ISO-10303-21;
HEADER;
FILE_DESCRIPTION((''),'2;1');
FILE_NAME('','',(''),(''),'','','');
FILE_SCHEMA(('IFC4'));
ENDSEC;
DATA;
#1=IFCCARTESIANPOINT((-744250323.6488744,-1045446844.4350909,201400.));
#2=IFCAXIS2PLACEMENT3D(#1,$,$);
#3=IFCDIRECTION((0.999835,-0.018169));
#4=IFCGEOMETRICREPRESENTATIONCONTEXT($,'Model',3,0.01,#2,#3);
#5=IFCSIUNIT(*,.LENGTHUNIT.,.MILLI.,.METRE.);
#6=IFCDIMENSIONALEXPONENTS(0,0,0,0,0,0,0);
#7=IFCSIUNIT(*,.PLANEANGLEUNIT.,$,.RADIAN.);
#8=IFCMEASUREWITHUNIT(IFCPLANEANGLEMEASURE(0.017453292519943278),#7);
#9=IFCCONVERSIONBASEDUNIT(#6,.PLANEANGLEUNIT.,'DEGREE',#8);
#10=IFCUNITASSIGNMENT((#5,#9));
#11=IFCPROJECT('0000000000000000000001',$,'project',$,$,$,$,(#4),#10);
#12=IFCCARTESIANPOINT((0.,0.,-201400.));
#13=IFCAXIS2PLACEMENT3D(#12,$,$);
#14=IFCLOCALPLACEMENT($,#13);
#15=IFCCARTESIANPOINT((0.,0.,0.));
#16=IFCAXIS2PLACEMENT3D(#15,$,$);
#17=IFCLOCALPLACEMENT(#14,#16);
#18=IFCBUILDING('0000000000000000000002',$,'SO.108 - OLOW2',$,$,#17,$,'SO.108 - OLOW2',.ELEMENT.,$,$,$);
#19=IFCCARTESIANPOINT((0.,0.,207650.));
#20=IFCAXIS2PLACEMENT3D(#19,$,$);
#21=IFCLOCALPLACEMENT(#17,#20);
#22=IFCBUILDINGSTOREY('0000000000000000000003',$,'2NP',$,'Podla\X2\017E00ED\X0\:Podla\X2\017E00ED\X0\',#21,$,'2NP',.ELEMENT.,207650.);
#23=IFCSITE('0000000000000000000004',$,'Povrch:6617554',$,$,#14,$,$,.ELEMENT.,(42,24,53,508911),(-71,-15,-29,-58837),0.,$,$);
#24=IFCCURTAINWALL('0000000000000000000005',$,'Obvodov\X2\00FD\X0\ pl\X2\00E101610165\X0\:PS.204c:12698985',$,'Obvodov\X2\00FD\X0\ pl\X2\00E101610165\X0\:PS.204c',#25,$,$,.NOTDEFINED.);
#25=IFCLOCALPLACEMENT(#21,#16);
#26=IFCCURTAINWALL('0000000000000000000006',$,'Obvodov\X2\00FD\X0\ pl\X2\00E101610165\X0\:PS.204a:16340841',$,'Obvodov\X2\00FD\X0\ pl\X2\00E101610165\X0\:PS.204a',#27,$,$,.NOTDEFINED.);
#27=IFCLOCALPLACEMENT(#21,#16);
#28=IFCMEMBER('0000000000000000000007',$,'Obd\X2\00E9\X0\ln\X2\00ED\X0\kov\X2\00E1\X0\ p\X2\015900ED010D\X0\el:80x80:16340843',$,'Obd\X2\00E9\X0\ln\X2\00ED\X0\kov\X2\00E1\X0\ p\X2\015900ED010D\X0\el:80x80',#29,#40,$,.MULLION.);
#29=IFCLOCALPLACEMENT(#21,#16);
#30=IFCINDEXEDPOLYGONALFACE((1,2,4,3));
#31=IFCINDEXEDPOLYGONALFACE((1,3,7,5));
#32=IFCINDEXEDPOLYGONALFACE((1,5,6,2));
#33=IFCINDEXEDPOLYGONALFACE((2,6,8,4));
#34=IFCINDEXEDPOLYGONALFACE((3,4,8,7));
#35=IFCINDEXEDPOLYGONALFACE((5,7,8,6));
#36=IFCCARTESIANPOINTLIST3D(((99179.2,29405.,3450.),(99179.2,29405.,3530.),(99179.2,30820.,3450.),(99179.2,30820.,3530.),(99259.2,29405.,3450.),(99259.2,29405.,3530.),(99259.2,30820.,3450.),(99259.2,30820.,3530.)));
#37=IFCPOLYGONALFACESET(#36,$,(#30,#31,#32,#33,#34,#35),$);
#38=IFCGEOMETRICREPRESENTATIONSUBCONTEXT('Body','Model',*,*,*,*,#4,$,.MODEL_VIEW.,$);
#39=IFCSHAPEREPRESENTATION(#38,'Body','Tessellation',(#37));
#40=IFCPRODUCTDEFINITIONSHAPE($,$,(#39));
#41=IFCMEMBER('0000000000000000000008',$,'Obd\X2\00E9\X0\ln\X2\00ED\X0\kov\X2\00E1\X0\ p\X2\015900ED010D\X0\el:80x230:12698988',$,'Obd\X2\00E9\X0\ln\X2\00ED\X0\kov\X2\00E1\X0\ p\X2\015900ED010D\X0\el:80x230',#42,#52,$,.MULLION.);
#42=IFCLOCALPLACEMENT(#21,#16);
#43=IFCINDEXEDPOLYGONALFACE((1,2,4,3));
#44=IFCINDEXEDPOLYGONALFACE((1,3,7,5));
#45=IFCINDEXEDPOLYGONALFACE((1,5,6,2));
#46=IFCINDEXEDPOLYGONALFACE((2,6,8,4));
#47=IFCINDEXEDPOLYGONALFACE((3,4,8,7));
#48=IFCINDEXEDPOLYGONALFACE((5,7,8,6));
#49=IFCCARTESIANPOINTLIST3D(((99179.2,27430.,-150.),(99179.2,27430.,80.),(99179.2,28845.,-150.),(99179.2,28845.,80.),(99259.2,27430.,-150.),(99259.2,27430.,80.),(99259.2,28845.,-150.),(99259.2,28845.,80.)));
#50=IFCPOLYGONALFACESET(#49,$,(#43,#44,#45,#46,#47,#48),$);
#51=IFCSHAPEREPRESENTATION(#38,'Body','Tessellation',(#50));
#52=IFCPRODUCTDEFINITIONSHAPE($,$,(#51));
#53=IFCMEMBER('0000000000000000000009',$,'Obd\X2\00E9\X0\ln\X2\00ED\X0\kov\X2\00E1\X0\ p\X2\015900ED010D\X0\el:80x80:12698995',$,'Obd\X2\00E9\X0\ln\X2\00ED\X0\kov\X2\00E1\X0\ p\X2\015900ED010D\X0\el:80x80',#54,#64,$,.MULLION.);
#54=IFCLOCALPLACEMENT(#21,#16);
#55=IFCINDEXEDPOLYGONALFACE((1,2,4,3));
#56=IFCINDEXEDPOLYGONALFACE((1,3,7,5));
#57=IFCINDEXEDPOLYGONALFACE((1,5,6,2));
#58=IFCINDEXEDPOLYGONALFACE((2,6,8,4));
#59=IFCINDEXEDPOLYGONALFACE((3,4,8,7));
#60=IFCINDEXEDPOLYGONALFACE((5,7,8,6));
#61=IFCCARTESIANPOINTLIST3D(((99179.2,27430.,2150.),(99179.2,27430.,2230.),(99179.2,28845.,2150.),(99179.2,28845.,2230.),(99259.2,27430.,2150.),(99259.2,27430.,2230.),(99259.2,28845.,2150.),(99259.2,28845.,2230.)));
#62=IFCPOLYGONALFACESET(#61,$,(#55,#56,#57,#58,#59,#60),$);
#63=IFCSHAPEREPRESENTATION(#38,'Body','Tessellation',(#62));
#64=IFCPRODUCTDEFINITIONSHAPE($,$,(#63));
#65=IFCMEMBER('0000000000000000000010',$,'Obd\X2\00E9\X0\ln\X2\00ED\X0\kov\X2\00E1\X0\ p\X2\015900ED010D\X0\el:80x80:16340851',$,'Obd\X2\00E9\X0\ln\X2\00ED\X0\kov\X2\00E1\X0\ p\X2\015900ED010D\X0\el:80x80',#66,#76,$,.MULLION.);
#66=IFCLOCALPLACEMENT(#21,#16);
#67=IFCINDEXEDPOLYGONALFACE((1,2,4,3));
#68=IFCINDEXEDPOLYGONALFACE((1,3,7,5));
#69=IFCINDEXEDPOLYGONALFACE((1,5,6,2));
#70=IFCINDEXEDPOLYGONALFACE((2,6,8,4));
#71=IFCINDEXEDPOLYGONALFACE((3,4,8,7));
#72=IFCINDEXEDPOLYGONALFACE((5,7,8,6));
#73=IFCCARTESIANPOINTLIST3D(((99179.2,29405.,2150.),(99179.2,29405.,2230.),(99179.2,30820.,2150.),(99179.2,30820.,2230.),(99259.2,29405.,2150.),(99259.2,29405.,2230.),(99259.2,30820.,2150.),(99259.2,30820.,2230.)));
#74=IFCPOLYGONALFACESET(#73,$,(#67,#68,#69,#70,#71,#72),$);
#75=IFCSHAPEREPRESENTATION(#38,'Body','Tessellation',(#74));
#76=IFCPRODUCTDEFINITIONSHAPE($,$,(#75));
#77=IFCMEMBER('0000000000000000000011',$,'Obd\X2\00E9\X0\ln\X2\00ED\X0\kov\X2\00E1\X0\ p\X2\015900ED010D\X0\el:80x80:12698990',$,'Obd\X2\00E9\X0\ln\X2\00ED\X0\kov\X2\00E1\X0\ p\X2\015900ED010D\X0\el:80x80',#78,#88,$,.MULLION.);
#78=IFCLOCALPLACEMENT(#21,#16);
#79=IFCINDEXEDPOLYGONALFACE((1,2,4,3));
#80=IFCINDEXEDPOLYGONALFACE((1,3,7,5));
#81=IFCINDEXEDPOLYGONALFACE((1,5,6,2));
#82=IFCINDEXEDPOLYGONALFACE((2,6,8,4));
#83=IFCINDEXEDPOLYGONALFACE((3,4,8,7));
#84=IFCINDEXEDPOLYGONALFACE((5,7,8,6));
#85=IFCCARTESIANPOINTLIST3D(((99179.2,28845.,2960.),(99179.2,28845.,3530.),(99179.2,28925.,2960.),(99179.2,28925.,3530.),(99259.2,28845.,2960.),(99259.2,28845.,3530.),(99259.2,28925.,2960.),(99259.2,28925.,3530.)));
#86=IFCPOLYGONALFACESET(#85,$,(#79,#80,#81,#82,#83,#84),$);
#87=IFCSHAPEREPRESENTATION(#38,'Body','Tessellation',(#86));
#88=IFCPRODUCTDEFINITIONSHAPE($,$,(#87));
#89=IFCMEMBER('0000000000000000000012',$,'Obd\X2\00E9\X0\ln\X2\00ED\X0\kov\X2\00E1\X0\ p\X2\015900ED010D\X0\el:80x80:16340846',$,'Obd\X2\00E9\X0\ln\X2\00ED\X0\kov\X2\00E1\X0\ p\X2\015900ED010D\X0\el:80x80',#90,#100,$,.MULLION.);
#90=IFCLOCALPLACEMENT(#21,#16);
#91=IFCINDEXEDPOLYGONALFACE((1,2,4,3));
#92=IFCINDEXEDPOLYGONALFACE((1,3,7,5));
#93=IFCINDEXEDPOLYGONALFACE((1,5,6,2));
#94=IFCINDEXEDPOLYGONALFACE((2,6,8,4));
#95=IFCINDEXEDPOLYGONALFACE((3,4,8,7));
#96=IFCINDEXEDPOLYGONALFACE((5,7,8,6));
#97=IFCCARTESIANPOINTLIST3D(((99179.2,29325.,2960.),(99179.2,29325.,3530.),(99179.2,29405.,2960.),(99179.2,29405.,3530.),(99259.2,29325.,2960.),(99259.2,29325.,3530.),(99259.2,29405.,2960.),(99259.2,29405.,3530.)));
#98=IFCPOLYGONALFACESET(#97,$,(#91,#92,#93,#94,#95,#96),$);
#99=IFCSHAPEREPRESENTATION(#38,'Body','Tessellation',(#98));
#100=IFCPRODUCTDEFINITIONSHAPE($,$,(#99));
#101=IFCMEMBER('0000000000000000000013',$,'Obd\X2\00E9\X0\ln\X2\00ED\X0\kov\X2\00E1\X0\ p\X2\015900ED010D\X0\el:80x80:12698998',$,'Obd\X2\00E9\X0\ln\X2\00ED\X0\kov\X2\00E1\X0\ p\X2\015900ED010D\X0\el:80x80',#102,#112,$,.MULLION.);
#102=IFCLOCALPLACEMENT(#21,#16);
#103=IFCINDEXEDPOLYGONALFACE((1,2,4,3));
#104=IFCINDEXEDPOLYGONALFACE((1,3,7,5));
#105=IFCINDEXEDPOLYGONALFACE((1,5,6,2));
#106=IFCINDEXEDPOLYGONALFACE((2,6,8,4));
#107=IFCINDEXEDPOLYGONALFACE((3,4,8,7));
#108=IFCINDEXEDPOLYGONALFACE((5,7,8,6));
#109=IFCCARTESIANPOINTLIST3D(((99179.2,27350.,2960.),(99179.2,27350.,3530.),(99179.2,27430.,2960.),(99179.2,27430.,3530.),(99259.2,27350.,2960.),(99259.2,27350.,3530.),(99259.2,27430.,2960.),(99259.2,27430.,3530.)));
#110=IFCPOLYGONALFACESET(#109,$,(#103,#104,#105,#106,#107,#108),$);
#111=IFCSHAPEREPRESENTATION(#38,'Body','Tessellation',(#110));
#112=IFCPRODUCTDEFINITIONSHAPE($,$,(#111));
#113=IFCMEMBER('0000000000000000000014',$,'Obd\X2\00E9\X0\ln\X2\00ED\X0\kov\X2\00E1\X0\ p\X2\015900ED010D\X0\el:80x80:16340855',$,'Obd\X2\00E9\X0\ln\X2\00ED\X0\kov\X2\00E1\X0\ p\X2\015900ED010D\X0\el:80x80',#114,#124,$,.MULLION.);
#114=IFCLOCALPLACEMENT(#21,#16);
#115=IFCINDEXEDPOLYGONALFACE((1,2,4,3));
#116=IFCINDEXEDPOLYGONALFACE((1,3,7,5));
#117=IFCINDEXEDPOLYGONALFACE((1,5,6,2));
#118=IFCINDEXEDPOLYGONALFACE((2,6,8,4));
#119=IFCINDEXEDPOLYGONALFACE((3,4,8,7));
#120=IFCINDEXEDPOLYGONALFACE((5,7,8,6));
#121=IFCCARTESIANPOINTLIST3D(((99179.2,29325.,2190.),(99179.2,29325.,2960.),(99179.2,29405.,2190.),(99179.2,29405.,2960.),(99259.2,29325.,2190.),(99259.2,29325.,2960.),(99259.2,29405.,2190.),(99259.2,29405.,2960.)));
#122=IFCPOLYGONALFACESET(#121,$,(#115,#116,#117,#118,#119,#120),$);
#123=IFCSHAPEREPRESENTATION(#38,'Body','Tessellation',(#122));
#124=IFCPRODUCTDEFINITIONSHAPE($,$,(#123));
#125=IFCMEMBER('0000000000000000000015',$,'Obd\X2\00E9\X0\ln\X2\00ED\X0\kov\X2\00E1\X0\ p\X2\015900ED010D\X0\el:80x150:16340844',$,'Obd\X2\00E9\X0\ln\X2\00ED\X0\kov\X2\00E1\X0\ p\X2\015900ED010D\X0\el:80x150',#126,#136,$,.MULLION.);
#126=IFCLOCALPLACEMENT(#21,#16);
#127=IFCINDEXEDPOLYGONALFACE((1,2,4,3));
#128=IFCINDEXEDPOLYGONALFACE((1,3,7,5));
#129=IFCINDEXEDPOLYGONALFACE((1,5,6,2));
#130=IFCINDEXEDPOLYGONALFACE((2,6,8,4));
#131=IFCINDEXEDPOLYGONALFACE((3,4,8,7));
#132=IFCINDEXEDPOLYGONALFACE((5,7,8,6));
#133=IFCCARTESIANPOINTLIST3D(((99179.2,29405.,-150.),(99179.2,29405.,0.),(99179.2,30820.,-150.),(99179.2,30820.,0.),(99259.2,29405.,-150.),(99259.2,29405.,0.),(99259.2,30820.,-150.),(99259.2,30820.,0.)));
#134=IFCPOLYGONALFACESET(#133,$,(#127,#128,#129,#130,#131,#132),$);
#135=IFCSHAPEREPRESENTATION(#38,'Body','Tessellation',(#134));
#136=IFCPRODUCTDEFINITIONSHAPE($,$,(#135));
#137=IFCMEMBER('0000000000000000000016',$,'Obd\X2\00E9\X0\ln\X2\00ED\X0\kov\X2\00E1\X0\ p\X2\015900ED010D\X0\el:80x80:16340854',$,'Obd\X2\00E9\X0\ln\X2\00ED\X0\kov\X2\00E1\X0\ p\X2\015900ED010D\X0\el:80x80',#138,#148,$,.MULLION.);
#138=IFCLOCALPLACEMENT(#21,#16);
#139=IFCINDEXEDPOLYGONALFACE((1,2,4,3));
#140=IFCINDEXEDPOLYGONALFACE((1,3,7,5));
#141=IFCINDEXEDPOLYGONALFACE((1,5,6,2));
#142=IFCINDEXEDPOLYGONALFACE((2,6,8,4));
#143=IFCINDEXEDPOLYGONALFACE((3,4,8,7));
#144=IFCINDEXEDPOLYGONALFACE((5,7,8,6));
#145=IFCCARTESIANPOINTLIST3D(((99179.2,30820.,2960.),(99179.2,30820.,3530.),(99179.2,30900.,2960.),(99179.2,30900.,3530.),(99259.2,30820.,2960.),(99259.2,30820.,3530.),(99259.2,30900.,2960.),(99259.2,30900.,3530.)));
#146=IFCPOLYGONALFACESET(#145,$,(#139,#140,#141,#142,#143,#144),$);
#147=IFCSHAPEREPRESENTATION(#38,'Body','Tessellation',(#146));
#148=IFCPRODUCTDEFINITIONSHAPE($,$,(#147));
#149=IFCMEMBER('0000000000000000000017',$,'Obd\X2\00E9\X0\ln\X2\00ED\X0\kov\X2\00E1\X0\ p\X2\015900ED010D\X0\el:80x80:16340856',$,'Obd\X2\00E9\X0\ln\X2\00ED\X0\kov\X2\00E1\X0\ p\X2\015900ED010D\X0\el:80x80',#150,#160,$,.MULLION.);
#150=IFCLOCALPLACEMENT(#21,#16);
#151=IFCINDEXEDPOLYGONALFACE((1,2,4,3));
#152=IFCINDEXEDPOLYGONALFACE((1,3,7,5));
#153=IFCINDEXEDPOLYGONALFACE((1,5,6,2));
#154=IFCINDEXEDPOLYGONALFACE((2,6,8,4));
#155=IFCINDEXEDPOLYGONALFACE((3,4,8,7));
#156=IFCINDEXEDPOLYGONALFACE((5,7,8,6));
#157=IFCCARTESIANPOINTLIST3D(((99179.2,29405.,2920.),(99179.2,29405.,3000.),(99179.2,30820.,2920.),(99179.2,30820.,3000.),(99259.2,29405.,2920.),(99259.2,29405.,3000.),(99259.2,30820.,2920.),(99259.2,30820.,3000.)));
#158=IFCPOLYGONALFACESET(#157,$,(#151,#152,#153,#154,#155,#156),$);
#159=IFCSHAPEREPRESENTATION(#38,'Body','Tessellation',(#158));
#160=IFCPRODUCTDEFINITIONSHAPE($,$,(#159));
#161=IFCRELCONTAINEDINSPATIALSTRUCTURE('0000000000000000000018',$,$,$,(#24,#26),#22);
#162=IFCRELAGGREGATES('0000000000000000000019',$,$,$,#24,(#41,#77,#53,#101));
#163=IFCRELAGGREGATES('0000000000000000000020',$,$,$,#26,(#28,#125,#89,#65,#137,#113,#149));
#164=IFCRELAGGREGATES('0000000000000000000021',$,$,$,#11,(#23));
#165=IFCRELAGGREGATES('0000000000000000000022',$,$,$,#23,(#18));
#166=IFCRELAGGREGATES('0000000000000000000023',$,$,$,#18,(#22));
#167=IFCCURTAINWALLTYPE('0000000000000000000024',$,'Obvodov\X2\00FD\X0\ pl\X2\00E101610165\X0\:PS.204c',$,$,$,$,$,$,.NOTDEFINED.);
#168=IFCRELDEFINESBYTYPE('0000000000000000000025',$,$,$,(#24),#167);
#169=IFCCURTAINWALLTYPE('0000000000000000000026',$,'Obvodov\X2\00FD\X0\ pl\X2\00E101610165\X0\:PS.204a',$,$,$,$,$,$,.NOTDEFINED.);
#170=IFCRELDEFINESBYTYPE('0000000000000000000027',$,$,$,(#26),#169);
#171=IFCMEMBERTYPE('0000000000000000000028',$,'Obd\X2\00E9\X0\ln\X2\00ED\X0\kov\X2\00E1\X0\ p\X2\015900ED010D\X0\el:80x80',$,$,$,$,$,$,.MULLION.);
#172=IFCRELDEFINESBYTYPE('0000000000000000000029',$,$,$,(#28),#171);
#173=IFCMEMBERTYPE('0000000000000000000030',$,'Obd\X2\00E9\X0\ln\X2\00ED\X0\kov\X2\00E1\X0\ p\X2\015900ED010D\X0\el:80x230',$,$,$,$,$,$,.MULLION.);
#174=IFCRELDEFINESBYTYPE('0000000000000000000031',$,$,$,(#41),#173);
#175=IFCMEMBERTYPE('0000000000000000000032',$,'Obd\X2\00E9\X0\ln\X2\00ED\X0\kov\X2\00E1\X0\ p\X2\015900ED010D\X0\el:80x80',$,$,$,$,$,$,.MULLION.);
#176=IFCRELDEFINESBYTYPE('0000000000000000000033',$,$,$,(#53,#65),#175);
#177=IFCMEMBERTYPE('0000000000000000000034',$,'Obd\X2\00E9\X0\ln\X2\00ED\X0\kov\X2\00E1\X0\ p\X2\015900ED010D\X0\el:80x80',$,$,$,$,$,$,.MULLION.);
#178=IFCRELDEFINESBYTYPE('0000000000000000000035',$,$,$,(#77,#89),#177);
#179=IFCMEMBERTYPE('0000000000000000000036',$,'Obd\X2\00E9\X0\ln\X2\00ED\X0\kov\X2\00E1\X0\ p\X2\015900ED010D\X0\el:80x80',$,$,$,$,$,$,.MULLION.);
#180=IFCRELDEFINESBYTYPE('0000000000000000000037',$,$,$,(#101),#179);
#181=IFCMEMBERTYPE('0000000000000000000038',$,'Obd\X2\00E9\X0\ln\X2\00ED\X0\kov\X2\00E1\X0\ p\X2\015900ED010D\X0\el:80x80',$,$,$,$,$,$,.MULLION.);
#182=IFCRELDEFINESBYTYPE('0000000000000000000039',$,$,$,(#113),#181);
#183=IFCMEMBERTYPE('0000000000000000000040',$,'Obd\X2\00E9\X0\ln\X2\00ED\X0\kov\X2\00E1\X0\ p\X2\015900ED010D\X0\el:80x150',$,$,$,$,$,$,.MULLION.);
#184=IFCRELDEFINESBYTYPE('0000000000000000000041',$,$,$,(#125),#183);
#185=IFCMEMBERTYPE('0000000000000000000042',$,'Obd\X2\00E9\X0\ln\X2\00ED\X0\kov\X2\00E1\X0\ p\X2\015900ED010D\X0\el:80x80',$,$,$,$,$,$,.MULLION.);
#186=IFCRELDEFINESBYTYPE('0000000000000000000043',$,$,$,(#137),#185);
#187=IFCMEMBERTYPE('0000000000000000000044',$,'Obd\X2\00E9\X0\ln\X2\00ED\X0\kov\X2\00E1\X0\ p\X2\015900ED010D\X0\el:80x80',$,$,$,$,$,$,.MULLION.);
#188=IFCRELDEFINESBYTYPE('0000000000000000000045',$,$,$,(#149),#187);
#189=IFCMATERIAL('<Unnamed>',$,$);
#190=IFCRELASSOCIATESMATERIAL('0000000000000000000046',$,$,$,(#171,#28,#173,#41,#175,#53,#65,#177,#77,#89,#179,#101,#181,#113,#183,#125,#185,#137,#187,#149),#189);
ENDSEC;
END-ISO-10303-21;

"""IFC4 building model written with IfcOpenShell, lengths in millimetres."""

from ifc_helpers import new_model, entity, si_unit, converted_unit, direction, frame, origin, place, context, subcontext, project, spatial, indexed_curve, outline, extrude, source, transform, mapped, material, type_object, type_shapes, element, aggregate, save


model = new_model("IFC4")

# Units and contexts
model_context = context("Model", 3, precision=0.01, world=frame((-744250323.6488744, -1045446844.4350909, 201400.0)), true_north=direction((0.999835, -0.018169)))
body_context = subcontext(model_context, "Body", "Model", "MODEL_VIEW")
ifc_project = project(units=[si_unit("LENGTHUNIT", "METRE", prefix="MILLI"), converted_unit("PLANEANGLEUNIT", "DEGREE", entity("IfcPlaneAngleMeasure", 0.017453292519943278), si_unit("PLANEANGLEUNIT", "RADIAN"), dimensions=[0, 0, 0, 0, 0, 0, 0])], contexts=[model_context])

# Site, building, storey
site_placement = place(None, frame((0.0, 0.0, -201400.0)))
site = spatial("IfcSite", under=ifc_project, at=site_placement, Name="Povrch:6617554", CompositionType="ELEMENT", RefLatitude=(42, 24, 53, 508911), RefLongitude=(-71, -15, -29, -58837), RefElevation=0.0)
building_placement = place(site_placement, origin())
building = spatial("IfcBuilding", under=site, at=building_placement, Name="SO.108 - OLOW2", LongName="SO.108 - OLOW2", CompositionType="ELEMENT")
storey_placement = place(building_placement, frame((0.0, 0.0, 207650.0)))
storey = spatial("IfcBuildingStorey", under=building, at=storey_placement, Name="2NP", ObjectType="Podlaží:Podlaží", LongName="2NP", CompositionType="ELEMENT", Elevation=207650.0)

# Shared definitions
ifc_material_1 = material(Name="<Unnamed>")

# Curtain walls
curtain_wall_type_1 = type_object("IfcCurtainWallType", Name="Obvodový plášť:PS.204c", PredefinedType="NOTDEFINED")
curtain_wall_1_placement = place(storey_placement, frame((0.0, 0.0, -207650.0)))
curtain_wall_1 = element("IfcCurtainWall", 1, at=curtain_wall_1_placement, inside=storey, type_object=curtain_wall_type_1, Name="Obvodový plášť:PS.204c:12698985", ObjectType="Obvodový plášť:PS.204c", PredefinedType="NOTDEFINED")
curtain_wall_type_2 = type_object("IfcCurtainWallType", Name="Obvodový plášť:PS.204a", PredefinedType="NOTDEFINED")
curtain_wall_2_placement = place(storey_placement, frame((0.0, 0.0, -207650.0)))
curtain_wall_2 = element("IfcCurtainWall", 2, at=curtain_wall_2_placement, inside=storey, type_object=curtain_wall_type_2, Name="Obvodový plášť:PS.204a:16340841", ObjectType="Obvodový plášť:PS.204a", PredefinedType="NOTDEFINED")

# Members
member_type_1 = type_object("IfcMemberType", Name="Obdélníková příčel:80x80", PredefinedType="MULLION", material=ifc_material_1)
shared_shape_1 = source(origin(), body_context, "Body", "SweptSolid", [
    extrude(outline(indexed_curve([(-40.0, -40.0), (40.0, -40.0), (40.0, 40.0), (-40.0, 40.0), (-40.0, -40.0)], self_intersect=False)), frame((-40.0, 0.0, -1415.0), z_axis=(0.0, 0.0, 1.0), x_axis=(-1.0, 0.0, 0.0)), (0.0, 0.0, 1.0), 1415.0),
])
type_shapes(member_type_1, [shared_shape_1])
member_1_placement = place(curtain_wall_2_placement, frame((99219.2, 30820.0, 211180.0), z_axis=(0.0, 1.0, 0.0), x_axis=(0.0, 0.0, 1.0)))
member_1 = element("IfcMember", 3, at=member_1_placement, type_object=member_type_1, material=ifc_material_1, Name="Obdélníková příčel:80x80:16340843", ObjectType="Obdélníková příčel:80x80", PredefinedType="MULLION", context=body_context, shape_type="MappedRepresentation", body=[
    mapped(shared_shape_1, transform((0.0, 0.0, 0.0), scale=1.0)),
])
member_type_2 = type_object("IfcMemberType", Name="Obdélníková příčel:80x230", PredefinedType="MULLION", material=ifc_material_1)
shared_shape_2 = source(origin(), body_context, "Body", "SweptSolid", [
    extrude(outline(indexed_curve([(-115.0, -40.0), (115.0, -40.0), (115.0, 40.0), (-115.0, 40.0), (-115.0, -40.0)], self_intersect=False)), frame((-115.0, 0.0, -1415.0), z_axis=(0.0, 0.0, 1.0), x_axis=(-1.0, 0.0, 0.0)), (0.0, 0.0, 1.0), 1415.0),
])
type_shapes(member_type_2, [shared_shape_2])
member_2_placement = place(curtain_wall_1_placement, frame((99219.2, 28845.0, 207500.0), z_axis=(0.0, 1.0, 0.0), x_axis=(0.0, 0.0, -1.0)))
member_2 = element("IfcMember", 4, at=member_2_placement, type_object=member_type_2, material=ifc_material_1, Name="Obdélníková příčel:80x230:12698988", ObjectType="Obdélníková příčel:80x230", PredefinedType="MULLION", context=body_context, shape_type="MappedRepresentation", body=[
    mapped(shared_shape_2, transform((0.0, 0.0, 0.0), scale=1.0)),
])
member_type_3 = type_object("IfcMemberType", Name="Obdélníková příčel:80x80", PredefinedType="MULLION", material=ifc_material_1)
shared_shape_3 = source(origin(), body_context, "Body", "SweptSolid", [
    extrude(outline(indexed_curve([(-40.0, -40.0), (40.0, -40.0), (40.0, 40.0), (-40.0, 40.0), (-40.0, -40.0)], self_intersect=False)), frame((0.0, 0.0, -1415.0), z_axis=(0.0, 0.0, 1.0), x_axis=(-1.0, 0.0, 0.0)), (0.0, 0.0, 1.0), 1415.0),
])
type_shapes(member_type_3, [shared_shape_3])
member_3_placement = place(curtain_wall_1_placement, frame((99219.2, 27430.0, 209840.0), z_axis=(0.0, -1.0, 0.0), x_axis=(0.0, 0.0, 1.0)))
member_3 = element("IfcMember", 5, at=member_3_placement, type_object=member_type_3, material=ifc_material_1, Name="Obdélníková příčel:80x80:12698995", ObjectType="Obdélníková příčel:80x80", PredefinedType="MULLION", context=body_context, shape_type="MappedRepresentation", body=[
    mapped(shared_shape_3, transform((0.0, 0.0, 0.0), scale=1.0)),
])
member_4_placement = place(curtain_wall_2_placement, frame((99219.2, 30820.0, 209840.0), z_axis=(0.0, 1.0, 0.0), x_axis=(0.0, 0.0, 1.0)))
member_4 = element("IfcMember", 6, at=member_4_placement, type_object=member_type_3, material=ifc_material_1, Name="Obdélníková příčel:80x80:16340851", ObjectType="Obdélníková příčel:80x80", PredefinedType="MULLION", context=body_context, shape_type="MappedRepresentation", body=[
    mapped(shared_shape_3, transform((0.0, 0.0, 0.0), scale=1.0)),
])
member_type_4 = type_object("IfcMemberType", Name="Obdélníková příčel:80x80", PredefinedType="MULLION", material=ifc_material_1)
shared_shape_4 = source(origin(), body_context, "Body", "SweptSolid", [
    extrude(outline(indexed_curve([(-40.0, -40.0), (40.0, -40.0), (40.0, 40.0), (-40.0, 40.0), (-40.0, -40.0)], self_intersect=False)), frame((-40.0, 0.0, -570.0), z_axis=(0.0, 0.0, 1.0), x_axis=(-1.0, 0.0, 0.0)), (0.0, 0.0, 1.0), 570.0),
])
type_shapes(member_type_4, [shared_shape_4])
member_5_placement = place(curtain_wall_1_placement, frame((99219.2, 28925.0, 211180.0), z_axis=(0.0, 0.0, 1.0), x_axis=(0.0, 1.0, 0.0)))
member_5 = element("IfcMember", 7, at=member_5_placement, type_object=member_type_4, material=ifc_material_1, Name="Obdélníková příčel:80x80:12698990", ObjectType="Obdélníková příčel:80x80", PredefinedType="MULLION", context=body_context, shape_type="MappedRepresentation", body=[
    mapped(shared_shape_4, transform((0.0, 0.0, 0.0), scale=1.0)),
])
member_6_placement = place(curtain_wall_2_placement, frame((99219.2, 29325.0, 211180.0), z_axis=(0.0, 0.0, 1.0), x_axis=(0.0, -1.0, 0.0)))
member_6 = element("IfcMember", 8, at=member_6_placement, type_object=member_type_4, material=ifc_material_1, Name="Obdélníková příčel:80x80:16340846", ObjectType="Obdélníková příčel:80x80", PredefinedType="MULLION", context=body_context, shape_type="MappedRepresentation", body=[
    mapped(shared_shape_4, transform((0.0, 0.0, 0.0), scale=1.0)),
])
member_type_5 = type_object("IfcMemberType", Name="Obdélníková příčel:80x80", PredefinedType="MULLION", material=ifc_material_1)
shared_shape_5 = source(origin(), body_context, "Body", "SweptSolid", [
    extrude(outline(indexed_curve([(-40.0, -40.0), (40.0, -40.0), (40.0, 40.0), (-40.0, 40.0), (-40.0, -40.0)], self_intersect=False)), frame((-40.0, 0.0, -570.0), z_axis=(0.0, 0.0, 1.0), x_axis=(-1.0, 0.0, 0.0)), (0.0, 0.0, 1.0), 570.0),
])
type_shapes(member_type_5, [shared_shape_5])
member_7_placement = place(curtain_wall_1_placement, frame((99219.2, 27350.0, 210610.0), z_axis=(0.0, 0.0, -1.0), x_axis=(0.0, -1.0, 0.0)))
member_7 = element("IfcMember", 9, at=member_7_placement, type_object=member_type_5, material=ifc_material_1, Name="Obdélníková příčel:80x80:12698998", ObjectType="Obdélníková příčel:80x80", PredefinedType="MULLION", context=body_context, shape_type="MappedRepresentation", body=[
    mapped(shared_shape_5, transform((0.0, 0.0, 0.0), scale=1.0)),
])
member_type_6 = type_object("IfcMemberType", Name="Obdélníková příčel:80x80", PredefinedType="MULLION", material=ifc_material_1)
shared_shape_6 = source(origin(), body_context, "Body", "SweptSolid", [
    extrude(outline(indexed_curve([(-40.0, -40.0), (40.0, -40.0), (40.0, 40.0), (-40.0, 40.0), (-40.0, -40.0)], self_intersect=False)), frame((-40.0, 0.0, -770.0), z_axis=(0.0, 0.0, 1.0), x_axis=(-1.0, 0.0, 0.0)), (0.0, 0.0, 1.0), 770.0),
])
type_shapes(member_type_6, [shared_shape_6])
member_8_placement = place(curtain_wall_2_placement, frame((99219.2, 29325.0, 210610.0), z_axis=(0.0, 0.0, 1.0), x_axis=(0.0, -1.0, 0.0)))
member_8 = element("IfcMember", 10, at=member_8_placement, type_object=member_type_6, material=ifc_material_1, Name="Obdélníková příčel:80x80:16340855", ObjectType="Obdélníková příčel:80x80", PredefinedType="MULLION", context=body_context, shape_type="MappedRepresentation", body=[
    mapped(shared_shape_6, transform((0.0, 0.0, 0.0), scale=1.0)),
])
member_type_7 = type_object("IfcMemberType", Name="Obdélníková příčel:80x150", PredefinedType="MULLION", material=ifc_material_1)
shared_shape_7 = source(origin(), body_context, "Body", "SweptSolid", [
    extrude(outline(indexed_curve([(-75.0, -40.0), (75.0, -40.0), (75.0, 40.0), (-75.0, 40.0), (-75.0, -40.0)], self_intersect=False)), frame((-75.0, 0.0, -1415.0), z_axis=(0.0, 0.0, 1.0), x_axis=(-1.0, 0.0, 0.0)), (0.0, 0.0, 1.0), 1415.0),
])
type_shapes(member_type_7, [shared_shape_7])
member_9_placement = place(curtain_wall_2_placement, frame((99219.2, 29405.0, 207500.0), z_axis=(0.0, -1.0, 0.0), x_axis=(0.0, 0.0, -1.0)))
member_9 = element("IfcMember", 11, at=member_9_placement, type_object=member_type_7, material=ifc_material_1, Name="Obdélníková příčel:80x150:16340844", ObjectType="Obdélníková příčel:80x150", PredefinedType="MULLION", context=body_context, shape_type="MappedRepresentation", body=[
    mapped(shared_shape_7, transform((0.0, 0.0, 0.0), scale=1.0)),
])
member_type_8 = type_object("IfcMemberType", Name="Obdélníková příčel:80x80", PredefinedType="MULLION", material=ifc_material_1)
shared_shape_8 = source(origin(), body_context, "Body", "SweptSolid", [
    extrude(outline(indexed_curve([(-40.0, -40.0), (40.0, -40.0), (40.0, 40.0), (-40.0, 40.0), (-40.0, -40.0)], self_intersect=False)), frame((-40.0, 0.0, -570.0), z_axis=(0.0, 0.0, 1.0), x_axis=(-1.0, 0.0, 0.0)), (0.0, 0.0, 1.0), 570.0),
])
type_shapes(member_type_8, [shared_shape_8])
member_10_placement = place(curtain_wall_2_placement, frame((99219.2, 30900.0, 210610.0), z_axis=(0.0, 0.0, -1.0), x_axis=(0.0, 1.0, 0.0)))
member_10 = element("IfcMember", 12, at=member_10_placement, type_object=member_type_8, material=ifc_material_1, Name="Obdélníková příčel:80x80:16340854", ObjectType="Obdélníková příčel:80x80", PredefinedType="MULLION", context=body_context, shape_type="MappedRepresentation", body=[
    mapped(shared_shape_8, transform((0.0, 0.0, 0.0), scale=1.0)),
])
member_type_9 = type_object("IfcMemberType", Name="Obdélníková příčel:80x80", PredefinedType="MULLION", material=ifc_material_1)
shared_shape_9 = source(origin(), body_context, "Body", "SweptSolid", [
    extrude(outline(indexed_curve([(-40.0, -40.0), (40.0, -40.0), (40.0, 40.0), (-40.0, 40.0), (-40.0, -40.0)], self_intersect=False)), frame((0.0, 0.0, -1415.0), z_axis=(0.0, 0.0, 1.0), x_axis=(-1.0, 0.0, 0.0)), (0.0, 0.0, 1.0), 1415.0),
])
type_shapes(member_type_9, [shared_shape_9])
member_11_placement = place(curtain_wall_2_placement, frame((99219.2, 30820.0, 210610.0), z_axis=(0.0, 1.0, 0.0), x_axis=(0.0, 0.0, 1.0)))
member_11 = element("IfcMember", 13, at=member_11_placement, type_object=member_type_9, material=ifc_material_1, Name="Obdélníková příčel:80x80:16340856", ObjectType="Obdélníková příčel:80x80", PredefinedType="MULLION", context=body_context, shape_type="MappedRepresentation", body=[
    mapped(shared_shape_9, transform((0.0, 0.0, 0.0), scale=1.0)),
])

aggregate(curtain_wall_1, [member_2, member_5, member_3, member_7])

aggregate(curtain_wall_2, [member_1, member_9, member_6, member_4, member_10, member_8, member_11])

save(model, "model.ifc")
